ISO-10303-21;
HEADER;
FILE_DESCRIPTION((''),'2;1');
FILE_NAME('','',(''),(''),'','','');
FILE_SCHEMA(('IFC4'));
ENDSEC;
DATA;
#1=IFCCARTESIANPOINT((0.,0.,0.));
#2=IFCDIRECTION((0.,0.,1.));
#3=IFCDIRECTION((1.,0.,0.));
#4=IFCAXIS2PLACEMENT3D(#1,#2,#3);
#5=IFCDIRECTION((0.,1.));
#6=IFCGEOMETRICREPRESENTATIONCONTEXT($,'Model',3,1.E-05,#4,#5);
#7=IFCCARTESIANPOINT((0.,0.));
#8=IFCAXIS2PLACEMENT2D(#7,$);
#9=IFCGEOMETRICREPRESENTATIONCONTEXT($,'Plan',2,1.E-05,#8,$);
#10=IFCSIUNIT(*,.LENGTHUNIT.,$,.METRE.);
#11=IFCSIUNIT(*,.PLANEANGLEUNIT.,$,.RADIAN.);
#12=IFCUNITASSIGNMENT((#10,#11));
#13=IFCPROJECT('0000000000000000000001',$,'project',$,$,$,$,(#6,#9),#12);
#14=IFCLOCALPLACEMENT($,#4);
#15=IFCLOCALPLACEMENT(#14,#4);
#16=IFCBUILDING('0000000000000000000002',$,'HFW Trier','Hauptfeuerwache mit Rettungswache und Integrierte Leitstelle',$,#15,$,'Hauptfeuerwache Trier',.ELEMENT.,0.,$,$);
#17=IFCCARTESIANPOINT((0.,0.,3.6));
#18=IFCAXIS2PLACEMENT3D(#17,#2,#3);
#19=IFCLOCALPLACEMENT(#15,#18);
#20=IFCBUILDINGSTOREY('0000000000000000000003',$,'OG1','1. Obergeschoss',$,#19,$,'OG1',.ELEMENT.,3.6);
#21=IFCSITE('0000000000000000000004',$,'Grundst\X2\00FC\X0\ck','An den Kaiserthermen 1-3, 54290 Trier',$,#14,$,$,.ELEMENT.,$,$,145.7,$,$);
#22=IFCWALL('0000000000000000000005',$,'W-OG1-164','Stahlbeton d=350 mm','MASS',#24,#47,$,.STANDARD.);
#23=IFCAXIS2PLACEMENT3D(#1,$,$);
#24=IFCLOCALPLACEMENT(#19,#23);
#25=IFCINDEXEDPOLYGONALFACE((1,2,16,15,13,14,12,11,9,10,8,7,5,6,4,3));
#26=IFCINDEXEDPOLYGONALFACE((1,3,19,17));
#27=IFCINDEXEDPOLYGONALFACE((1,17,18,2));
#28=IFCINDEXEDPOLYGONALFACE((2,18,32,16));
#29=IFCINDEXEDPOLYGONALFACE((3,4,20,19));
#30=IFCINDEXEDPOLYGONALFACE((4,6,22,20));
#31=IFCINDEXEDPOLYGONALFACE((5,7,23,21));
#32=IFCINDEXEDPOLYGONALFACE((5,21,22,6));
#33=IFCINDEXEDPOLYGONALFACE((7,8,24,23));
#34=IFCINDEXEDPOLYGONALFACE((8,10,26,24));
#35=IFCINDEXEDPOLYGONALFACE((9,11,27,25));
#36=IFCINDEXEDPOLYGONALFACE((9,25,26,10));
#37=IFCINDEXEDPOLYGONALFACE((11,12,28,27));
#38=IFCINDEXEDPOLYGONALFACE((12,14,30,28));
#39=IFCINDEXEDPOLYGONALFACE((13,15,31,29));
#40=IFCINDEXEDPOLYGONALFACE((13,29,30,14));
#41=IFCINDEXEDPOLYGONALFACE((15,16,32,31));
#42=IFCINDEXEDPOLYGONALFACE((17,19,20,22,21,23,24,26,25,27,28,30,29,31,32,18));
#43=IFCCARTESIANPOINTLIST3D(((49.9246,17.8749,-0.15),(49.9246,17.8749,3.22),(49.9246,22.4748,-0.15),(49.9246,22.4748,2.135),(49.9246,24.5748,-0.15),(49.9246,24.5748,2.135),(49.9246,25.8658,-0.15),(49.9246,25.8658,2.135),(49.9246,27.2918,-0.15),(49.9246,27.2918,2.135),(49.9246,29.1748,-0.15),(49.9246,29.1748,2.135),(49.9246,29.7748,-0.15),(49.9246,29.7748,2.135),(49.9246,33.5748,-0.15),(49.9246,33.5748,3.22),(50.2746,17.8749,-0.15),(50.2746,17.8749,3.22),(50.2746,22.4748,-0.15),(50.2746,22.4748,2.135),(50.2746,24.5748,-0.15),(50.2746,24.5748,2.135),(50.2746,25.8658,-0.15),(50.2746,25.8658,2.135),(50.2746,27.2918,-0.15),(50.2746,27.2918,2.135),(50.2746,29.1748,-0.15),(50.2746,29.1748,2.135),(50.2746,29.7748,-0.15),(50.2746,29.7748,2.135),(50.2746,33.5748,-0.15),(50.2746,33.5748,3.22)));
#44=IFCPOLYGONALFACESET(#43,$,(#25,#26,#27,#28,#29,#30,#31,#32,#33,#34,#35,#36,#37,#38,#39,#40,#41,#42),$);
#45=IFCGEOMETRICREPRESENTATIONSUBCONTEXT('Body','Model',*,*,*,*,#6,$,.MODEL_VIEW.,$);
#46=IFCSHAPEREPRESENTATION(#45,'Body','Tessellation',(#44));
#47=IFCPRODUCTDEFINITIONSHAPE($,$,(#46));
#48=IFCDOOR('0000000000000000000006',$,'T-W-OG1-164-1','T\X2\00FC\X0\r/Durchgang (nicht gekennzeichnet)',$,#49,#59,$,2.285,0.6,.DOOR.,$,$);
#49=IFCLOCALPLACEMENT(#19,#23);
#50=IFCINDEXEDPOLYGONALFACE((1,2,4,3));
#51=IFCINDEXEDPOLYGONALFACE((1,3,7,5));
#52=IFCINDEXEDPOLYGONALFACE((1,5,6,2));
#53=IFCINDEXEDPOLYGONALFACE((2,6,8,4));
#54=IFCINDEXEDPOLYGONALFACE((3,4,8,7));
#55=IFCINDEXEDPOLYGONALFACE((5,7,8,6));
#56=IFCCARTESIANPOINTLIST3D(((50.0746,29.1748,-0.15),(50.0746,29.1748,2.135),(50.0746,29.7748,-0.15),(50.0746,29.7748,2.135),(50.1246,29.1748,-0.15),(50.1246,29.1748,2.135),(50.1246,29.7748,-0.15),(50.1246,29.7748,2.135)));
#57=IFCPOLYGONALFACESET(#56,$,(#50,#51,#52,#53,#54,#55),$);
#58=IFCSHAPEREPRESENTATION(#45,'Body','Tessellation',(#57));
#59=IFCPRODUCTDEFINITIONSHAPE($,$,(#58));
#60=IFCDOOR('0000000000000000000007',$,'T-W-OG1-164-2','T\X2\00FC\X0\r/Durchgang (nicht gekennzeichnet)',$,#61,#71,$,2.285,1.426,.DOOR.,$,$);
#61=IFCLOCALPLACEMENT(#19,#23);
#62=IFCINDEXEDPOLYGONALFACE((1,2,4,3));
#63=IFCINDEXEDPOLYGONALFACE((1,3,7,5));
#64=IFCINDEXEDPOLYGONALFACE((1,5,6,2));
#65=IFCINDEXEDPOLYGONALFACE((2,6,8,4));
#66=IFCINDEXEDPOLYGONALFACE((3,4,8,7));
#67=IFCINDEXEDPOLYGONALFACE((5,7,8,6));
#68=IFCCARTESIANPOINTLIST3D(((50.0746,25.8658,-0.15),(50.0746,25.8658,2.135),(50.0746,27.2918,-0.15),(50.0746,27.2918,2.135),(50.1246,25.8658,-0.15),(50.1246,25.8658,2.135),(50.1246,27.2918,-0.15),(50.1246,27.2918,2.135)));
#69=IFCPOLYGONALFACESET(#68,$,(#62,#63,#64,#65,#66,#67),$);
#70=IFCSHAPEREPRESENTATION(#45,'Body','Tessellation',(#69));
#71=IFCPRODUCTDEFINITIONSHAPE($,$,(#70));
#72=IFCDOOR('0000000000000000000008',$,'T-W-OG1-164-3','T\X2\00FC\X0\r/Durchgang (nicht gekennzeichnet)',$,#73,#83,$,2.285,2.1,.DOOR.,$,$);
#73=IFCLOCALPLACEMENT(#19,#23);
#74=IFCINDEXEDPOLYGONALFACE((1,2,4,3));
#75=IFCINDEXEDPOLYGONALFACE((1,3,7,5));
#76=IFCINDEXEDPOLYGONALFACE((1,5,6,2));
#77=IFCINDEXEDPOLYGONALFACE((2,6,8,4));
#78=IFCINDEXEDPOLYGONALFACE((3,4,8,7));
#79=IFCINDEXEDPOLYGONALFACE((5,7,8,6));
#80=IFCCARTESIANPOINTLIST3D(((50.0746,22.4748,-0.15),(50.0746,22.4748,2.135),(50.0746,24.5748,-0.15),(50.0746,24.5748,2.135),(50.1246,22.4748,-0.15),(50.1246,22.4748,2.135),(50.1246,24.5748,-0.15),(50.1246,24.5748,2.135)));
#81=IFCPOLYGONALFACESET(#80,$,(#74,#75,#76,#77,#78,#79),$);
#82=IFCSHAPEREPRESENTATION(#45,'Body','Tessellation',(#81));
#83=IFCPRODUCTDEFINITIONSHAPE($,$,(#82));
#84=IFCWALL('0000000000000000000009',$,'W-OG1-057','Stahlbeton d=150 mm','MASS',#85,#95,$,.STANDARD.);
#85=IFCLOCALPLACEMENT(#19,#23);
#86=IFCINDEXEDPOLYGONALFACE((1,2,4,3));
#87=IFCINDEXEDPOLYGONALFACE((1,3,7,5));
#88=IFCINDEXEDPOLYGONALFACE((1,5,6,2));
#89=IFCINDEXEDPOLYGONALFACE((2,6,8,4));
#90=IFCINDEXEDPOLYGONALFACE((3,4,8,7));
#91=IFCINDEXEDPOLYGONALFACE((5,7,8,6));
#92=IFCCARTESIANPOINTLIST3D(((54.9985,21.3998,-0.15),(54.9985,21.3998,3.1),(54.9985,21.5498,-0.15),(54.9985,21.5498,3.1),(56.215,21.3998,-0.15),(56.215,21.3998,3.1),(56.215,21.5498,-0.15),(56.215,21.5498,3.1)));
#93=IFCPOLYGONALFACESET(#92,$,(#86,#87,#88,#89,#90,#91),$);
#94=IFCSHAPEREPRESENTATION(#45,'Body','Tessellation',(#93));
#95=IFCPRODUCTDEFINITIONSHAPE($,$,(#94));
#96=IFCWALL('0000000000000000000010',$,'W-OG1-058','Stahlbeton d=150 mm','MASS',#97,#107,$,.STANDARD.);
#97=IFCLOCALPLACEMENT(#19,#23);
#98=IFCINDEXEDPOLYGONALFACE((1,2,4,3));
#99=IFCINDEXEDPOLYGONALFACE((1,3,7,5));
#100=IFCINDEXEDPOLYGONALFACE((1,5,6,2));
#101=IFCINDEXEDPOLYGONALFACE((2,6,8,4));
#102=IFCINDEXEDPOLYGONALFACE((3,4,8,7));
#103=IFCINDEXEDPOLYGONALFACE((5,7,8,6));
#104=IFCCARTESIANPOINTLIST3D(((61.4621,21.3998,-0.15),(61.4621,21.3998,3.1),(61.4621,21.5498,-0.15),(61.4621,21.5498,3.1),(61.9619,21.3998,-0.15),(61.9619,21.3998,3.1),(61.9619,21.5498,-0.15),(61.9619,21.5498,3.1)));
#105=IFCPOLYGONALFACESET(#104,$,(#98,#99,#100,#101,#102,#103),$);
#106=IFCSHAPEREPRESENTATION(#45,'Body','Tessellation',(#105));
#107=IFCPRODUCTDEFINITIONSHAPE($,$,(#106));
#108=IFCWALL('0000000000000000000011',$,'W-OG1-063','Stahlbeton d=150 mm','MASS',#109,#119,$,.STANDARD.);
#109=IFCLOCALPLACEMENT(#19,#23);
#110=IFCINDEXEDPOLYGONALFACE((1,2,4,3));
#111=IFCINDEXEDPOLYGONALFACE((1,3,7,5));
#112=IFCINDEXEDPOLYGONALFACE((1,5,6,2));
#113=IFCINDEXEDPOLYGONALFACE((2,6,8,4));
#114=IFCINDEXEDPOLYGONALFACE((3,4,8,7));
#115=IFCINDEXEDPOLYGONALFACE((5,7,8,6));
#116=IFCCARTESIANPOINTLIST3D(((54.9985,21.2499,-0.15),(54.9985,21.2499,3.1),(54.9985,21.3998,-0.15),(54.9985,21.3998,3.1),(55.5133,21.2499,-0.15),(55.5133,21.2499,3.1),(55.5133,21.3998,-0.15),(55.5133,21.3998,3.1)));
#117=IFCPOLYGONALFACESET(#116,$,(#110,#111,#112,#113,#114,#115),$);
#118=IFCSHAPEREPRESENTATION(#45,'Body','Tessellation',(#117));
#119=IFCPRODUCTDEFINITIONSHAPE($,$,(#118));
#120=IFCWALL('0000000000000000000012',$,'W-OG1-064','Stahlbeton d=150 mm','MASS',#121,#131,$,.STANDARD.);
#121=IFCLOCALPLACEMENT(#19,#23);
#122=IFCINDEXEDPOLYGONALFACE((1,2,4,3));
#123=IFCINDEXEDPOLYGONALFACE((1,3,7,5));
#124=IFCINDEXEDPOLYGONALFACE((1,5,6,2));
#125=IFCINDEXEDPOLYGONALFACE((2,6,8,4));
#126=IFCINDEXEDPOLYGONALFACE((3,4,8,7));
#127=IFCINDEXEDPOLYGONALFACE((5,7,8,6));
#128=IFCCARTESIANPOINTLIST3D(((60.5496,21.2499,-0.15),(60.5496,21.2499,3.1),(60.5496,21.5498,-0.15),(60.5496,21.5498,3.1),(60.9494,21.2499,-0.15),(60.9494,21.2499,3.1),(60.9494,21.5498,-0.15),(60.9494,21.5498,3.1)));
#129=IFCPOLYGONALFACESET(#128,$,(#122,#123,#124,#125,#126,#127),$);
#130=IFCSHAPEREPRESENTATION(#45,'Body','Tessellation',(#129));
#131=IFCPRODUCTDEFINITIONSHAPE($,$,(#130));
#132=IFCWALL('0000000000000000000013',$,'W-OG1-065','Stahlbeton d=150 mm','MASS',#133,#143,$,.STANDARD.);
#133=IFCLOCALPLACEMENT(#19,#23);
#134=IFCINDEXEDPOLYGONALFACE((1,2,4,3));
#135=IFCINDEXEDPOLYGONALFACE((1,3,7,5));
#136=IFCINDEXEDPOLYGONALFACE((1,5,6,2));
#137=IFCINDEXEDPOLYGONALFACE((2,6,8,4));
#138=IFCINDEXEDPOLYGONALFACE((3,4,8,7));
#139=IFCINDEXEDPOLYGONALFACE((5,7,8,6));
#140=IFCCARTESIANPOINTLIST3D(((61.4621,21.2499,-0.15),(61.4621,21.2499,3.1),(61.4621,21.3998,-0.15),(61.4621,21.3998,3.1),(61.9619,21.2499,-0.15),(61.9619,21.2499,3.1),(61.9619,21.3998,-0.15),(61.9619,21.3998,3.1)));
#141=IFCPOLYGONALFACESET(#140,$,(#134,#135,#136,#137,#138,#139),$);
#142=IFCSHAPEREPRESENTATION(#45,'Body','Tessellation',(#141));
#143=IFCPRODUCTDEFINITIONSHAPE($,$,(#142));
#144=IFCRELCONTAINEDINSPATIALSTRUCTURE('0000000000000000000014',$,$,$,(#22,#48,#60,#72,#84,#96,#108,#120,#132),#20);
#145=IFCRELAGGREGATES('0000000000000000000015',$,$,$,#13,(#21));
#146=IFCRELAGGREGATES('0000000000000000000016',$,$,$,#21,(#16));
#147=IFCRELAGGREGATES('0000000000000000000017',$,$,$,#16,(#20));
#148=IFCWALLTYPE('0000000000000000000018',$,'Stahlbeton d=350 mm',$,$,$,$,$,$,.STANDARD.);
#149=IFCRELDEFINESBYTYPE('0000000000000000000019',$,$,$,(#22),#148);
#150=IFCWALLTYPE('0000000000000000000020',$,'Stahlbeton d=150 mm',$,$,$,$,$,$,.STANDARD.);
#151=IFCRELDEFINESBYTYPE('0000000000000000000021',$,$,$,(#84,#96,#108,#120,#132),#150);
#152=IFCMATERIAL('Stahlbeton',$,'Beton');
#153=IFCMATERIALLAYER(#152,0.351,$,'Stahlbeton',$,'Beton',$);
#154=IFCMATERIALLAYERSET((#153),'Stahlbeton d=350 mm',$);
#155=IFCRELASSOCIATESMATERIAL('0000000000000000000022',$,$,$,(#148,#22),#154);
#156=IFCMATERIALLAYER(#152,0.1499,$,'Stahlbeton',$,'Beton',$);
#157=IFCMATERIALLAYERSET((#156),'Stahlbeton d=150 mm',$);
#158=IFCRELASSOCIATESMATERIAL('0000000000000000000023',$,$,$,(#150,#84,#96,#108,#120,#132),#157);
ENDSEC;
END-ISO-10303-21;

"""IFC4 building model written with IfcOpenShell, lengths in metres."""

from ifc_helpers import new_model, si_unit, direction, frame, frame_2d, origin_with_axes, origin_2d, place, context, subcontext, project, spatial, rectangle, extrude, material, layer, layer_set, layer_usage, type_object, element, fill, save


model = new_model("IFC4")

# Units and contexts
model_context = context("Model", 3, precision=1e-05, world=origin_with_axes(), true_north=direction((0.0, 1.0)))
plan_context = context("Plan", 2, precision=1e-05, world=origin_2d())
body_context = subcontext(model_context, "Body", "Model", "MODEL_VIEW")
ifc_project = project(units=[si_unit("LENGTHUNIT", "METRE"), si_unit("PLANEANGLEUNIT", "RADIAN")], contexts=[model_context, plan_context])

# Site, building, storey
site_placement = place(None, origin_with_axes())
site = spatial("IfcSite", under=ifc_project, at=site_placement, Name="Grundstück", Description="An den Kaiserthermen 1-3, 54290 Trier", CompositionType="ELEMENT", RefElevation=145.7)
building_placement = place(site_placement, origin_with_axes())
building = spatial("IfcBuilding", under=site, at=building_placement, Name="HFW Trier", Description="Hauptfeuerwache mit Rettungswache und Integrierte Leitstelle", LongName="Hauptfeuerwache Trier", CompositionType="ELEMENT", ElevationOfRefHeight=0.0)
storey_placement = place(building_placement, frame((0.0, 0.0, 3.6), z_axis=(0.0, 0.0, 1.0), x_axis=(1.0, 0.0, 0.0)))
storey = spatial("IfcBuildingStorey", under=building, at=storey_placement, Name="OG1", Description="1. Obergeschoss", LongName="OG1", CompositionType="ELEMENT", Elevation=3.6)

# Shared definitions
ifc_material = material(Name="Stahlbeton", Category="Beton")

# Shared definitions
ifc_layer_1 = layer(ifc_material, 0.351, Name="Stahlbeton", Category="Beton")
ifc_layer_set_1 = layer_set([ifc_layer_1], Name="Stahlbeton d=350 mm")
wall_type_1 = type_object("IfcWallType", Name="Stahlbeton d=350 mm", PredefinedType="STANDARD", material=ifc_layer_set_1)

# Wall, openings, doors
ifc_layer_usage_1 = layer_usage(ifc_layer_set_1, "AXIS2", "POSITIVE", -0.175)
wall_1_placement = place(storey_placement, frame((50.0996, 33.5748, -0.15), z_axis=(0.0, 0.0, 1.0), x_axis=(0.0, -1.0, 0.0)))
wall_1 = element("IfcWall", 1, at=wall_1_placement, inside=storey, type_object=wall_type_1, material=ifc_layer_usage_1, Name="W-OG1-164", Description="Stahlbeton d=350 mm", ObjectType="MASS", PredefinedType="STANDARD", context=body_context, shape_type="SweptSolid", body=[
    extrude(rectangle(XDim=15.6999, YDim=0.35, at=frame_2d((7.85, 0.0))), origin_with_axes(), (0.0, 0.0, 1.0), 3.37),
])
opening_1_placement = place(wall_1_placement, frame((3.8, 0.0, 0.0), z_axis=(0.0, 0.0, 1.0), x_axis=(1.0, 0.0, 0.0)))
opening_1 = element("IfcOpeningElement", 2, at=opening_1_placement, cuts=wall_1, PredefinedType="OPENING", context=body_context, shape_type="SweptSolid", body=[
    extrude(rectangle(XDim=0.6, YDim=0.45, at=frame_2d((0.3, 0.0))), origin_with_axes(), (0.0, 0.0, 1.0), 2.285),
])
opening_2_placement = place(wall_1_placement, frame((6.283, 0.0, 0.0), z_axis=(0.0, 0.0, 1.0), x_axis=(1.0, 0.0, 0.0)))
opening_2 = element("IfcOpeningElement", 3, at=opening_2_placement, cuts=wall_1, PredefinedType="OPENING", context=body_context, shape_type="SweptSolid", body=[
    extrude(rectangle(XDim=1.426, YDim=0.45, at=frame_2d((0.713, 0.0))), origin_with_axes(), (0.0, 0.0, 1.0), 2.285),
])
opening_3_placement = place(wall_1_placement, frame((9.0, 0.0, 0.0), z_axis=(0.0, 0.0, 1.0), x_axis=(1.0, 0.0, 0.0)))
opening_3 = element("IfcOpeningElement", 4, at=opening_3_placement, cuts=wall_1, PredefinedType="OPENING", context=body_context, shape_type="SweptSolid", body=[
    extrude(rectangle(XDim=2.1, YDim=0.45, at=frame_2d((1.05, 0.0))), origin_with_axes(), (0.0, 0.0, 1.0), 2.285),
])
door_1_placement = place(wall_1_placement, frame((3.8, 0.0, 0.0), z_axis=(0.0, 0.0, 1.0), x_axis=(1.0, 0.0, 0.0)))
door_1 = element("IfcDoor", 5, at=door_1_placement, inside=storey, Name="T-W-OG1-164-1", Description="Tür/Durchgang (nicht gekennzeichnet)", OverallHeight=2.285, OverallWidth=0.6, PredefinedType="DOOR", context=body_context, shape_type="SweptSolid", body=[
    extrude(rectangle(XDim=0.6, YDim=0.05, at=frame_2d((0.3, 0.0))), origin_with_axes(), (0.0, 0.0, 1.0), 2.285),
])
fill(opening_1, door_1)
door_2_placement = place(wall_1_placement, frame((6.283, 0.0, 0.0), z_axis=(0.0, 0.0, 1.0), x_axis=(1.0, 0.0, 0.0)))
door_2 = element("IfcDoor", 6, at=door_2_placement, inside=storey, Name="T-W-OG1-164-2", Description="Tür/Durchgang (nicht gekennzeichnet)", OverallHeight=2.285, OverallWidth=1.426, PredefinedType="DOOR", context=body_context, shape_type="SweptSolid", body=[
    extrude(rectangle(XDim=1.426, YDim=0.05, at=frame_2d((0.713, 0.0))), origin_with_axes(), (0.0, 0.0, 1.0), 2.285),
])
fill(opening_2, door_2)
door_3_placement = place(wall_1_placement, frame((9.0, 0.0, 0.0), z_axis=(0.0, 0.0, 1.0), x_axis=(1.0, 0.0, 0.0)))
door_3 = element("IfcDoor", 7, at=door_3_placement, inside=storey, Name="T-W-OG1-164-3", Description="Tür/Durchgang (nicht gekennzeichnet)", OverallHeight=2.285, OverallWidth=2.1, PredefinedType="DOOR", context=body_context, shape_type="SweptSolid", body=[
    extrude(rectangle(XDim=2.1, YDim=0.05, at=frame_2d((1.05, 0.0))), origin_with_axes(), (0.0, 0.0, 1.0), 2.285),
])
fill(opening_3, door_3)

# Walls
ifc_layer_2 = layer(ifc_material, 0.1499, Name="Stahlbeton", Category="Beton")
ifc_layer_set_2 = layer_set([ifc_layer_2], Name="Stahlbeton d=150 mm")
ifc_layer_usage_2 = layer_usage(ifc_layer_set_2, "AXIS2", "POSITIVE", -0.075)
wall_type_2 = type_object("IfcWallType", Name="Stahlbeton d=150 mm", PredefinedType="STANDARD", material=ifc_layer_set_2)
wall_2_placement = place(storey_placement, frame((54.9985, 21.4748, -0.15), z_axis=(0.0, 0.0, 1.0), x_axis=(1.0, 0.0, 0.0)))
element("IfcWall", 8, at=wall_2_placement, inside=storey, type_object=wall_type_2, material=ifc_layer_usage_2, Name="W-OG1-057", Description="Stahlbeton d=150 mm", ObjectType="MASS", PredefinedType="STANDARD", context=body_context, shape_type="SweptSolid", body=[
    extrude(rectangle(XDim=1.2165, YDim=0.1499, at=frame_2d((0.6083, 0.0))), origin_with_axes(), (0.0, 0.0, 1.0), 3.25),
])
ifc_layer_usage_3 = layer_usage(ifc_layer_set_2, "AXIS2", "POSITIVE", -0.075)
wall_3_placement = place(storey_placement, frame((61.4621, 21.4748, -0.15), z_axis=(0.0, 0.0, 1.0), x_axis=(1.0, 0.0, 0.0)))
element("IfcWall", 9, at=wall_3_placement, inside=storey, type_object=wall_type_2, material=ifc_layer_usage_3, Name="W-OG1-058", Description="Stahlbeton d=150 mm", ObjectType="MASS", PredefinedType="STANDARD", context=body_context, shape_type="SweptSolid", body=[
    extrude(rectangle(XDim=0.4998, YDim=0.1499, at=frame_2d((0.2499, 0.0))), origin_with_axes(), (0.0, 0.0, 1.0), 3.25),
])
ifc_layer_usage_4 = layer_usage(ifc_layer_set_2, "AXIS2", "POSITIVE", -0.075)
wall_4_placement = place(storey_placement, frame((54.9985, 21.3249, -0.15), z_axis=(0.0, 0.0, 1.0), x_axis=(1.0, 0.0, 0.0)))
element("IfcWall", 10, at=wall_4_placement, inside=storey, type_object=wall_type_2, material=ifc_layer_usage_4, Name="W-OG1-063", Description="Stahlbeton d=150 mm", ObjectType="MASS", PredefinedType="STANDARD", context=body_context, shape_type="SweptSolid", body=[
    extrude(rectangle(XDim=0.5148, YDim=0.1499, at=frame_2d((0.2574, 0.0))), origin_with_axes(), (0.0, 0.0, 1.0), 3.25),
])
ifc_layer_usage_5 = layer_usage(ifc_layer_set_2, "AXIS2", "POSITIVE", -0.1499)
wall_5_placement = place(storey_placement, frame((60.5496, 21.3999, -0.15), z_axis=(0.0, 0.0, 1.0), x_axis=(1.0, 0.0, 0.0)))
element("IfcWall", 11, at=wall_5_placement, inside=storey, type_object=wall_type_2, material=ifc_layer_usage_5, Name="W-OG1-064", Description="Stahlbeton d=150 mm", ObjectType="MASS", PredefinedType="STANDARD", context=body_context, shape_type="SweptSolid", body=[
    extrude(rectangle(XDim=0.3998, YDim=0.2999, at=frame_2d((0.1999, 0.0))), origin_with_axes(), (0.0, 0.0, 1.0), 3.25),
])
ifc_layer_usage_6 = layer_usage(ifc_layer_set_2, "AXIS2", "POSITIVE", -0.075)
wall_6_placement = place(storey_placement, frame((61.4621, 21.3249, -0.15), z_axis=(0.0, 0.0, 1.0), x_axis=(1.0, 0.0, 0.0)))
element("IfcWall", 12, at=wall_6_placement, inside=storey, type_object=wall_type_2, material=ifc_layer_usage_6, Name="W-OG1-065", Description="Stahlbeton d=150 mm", ObjectType="MASS", PredefinedType="STANDARD", context=body_context, shape_type="SweptSolid", body=[
    extrude(rectangle(XDim=0.4998, YDim=0.1499, at=frame_2d((0.2499, 0.0))), origin_with_axes(), (0.0, 0.0, 1.0), 3.25),
])

save(model, "model.ifc")
